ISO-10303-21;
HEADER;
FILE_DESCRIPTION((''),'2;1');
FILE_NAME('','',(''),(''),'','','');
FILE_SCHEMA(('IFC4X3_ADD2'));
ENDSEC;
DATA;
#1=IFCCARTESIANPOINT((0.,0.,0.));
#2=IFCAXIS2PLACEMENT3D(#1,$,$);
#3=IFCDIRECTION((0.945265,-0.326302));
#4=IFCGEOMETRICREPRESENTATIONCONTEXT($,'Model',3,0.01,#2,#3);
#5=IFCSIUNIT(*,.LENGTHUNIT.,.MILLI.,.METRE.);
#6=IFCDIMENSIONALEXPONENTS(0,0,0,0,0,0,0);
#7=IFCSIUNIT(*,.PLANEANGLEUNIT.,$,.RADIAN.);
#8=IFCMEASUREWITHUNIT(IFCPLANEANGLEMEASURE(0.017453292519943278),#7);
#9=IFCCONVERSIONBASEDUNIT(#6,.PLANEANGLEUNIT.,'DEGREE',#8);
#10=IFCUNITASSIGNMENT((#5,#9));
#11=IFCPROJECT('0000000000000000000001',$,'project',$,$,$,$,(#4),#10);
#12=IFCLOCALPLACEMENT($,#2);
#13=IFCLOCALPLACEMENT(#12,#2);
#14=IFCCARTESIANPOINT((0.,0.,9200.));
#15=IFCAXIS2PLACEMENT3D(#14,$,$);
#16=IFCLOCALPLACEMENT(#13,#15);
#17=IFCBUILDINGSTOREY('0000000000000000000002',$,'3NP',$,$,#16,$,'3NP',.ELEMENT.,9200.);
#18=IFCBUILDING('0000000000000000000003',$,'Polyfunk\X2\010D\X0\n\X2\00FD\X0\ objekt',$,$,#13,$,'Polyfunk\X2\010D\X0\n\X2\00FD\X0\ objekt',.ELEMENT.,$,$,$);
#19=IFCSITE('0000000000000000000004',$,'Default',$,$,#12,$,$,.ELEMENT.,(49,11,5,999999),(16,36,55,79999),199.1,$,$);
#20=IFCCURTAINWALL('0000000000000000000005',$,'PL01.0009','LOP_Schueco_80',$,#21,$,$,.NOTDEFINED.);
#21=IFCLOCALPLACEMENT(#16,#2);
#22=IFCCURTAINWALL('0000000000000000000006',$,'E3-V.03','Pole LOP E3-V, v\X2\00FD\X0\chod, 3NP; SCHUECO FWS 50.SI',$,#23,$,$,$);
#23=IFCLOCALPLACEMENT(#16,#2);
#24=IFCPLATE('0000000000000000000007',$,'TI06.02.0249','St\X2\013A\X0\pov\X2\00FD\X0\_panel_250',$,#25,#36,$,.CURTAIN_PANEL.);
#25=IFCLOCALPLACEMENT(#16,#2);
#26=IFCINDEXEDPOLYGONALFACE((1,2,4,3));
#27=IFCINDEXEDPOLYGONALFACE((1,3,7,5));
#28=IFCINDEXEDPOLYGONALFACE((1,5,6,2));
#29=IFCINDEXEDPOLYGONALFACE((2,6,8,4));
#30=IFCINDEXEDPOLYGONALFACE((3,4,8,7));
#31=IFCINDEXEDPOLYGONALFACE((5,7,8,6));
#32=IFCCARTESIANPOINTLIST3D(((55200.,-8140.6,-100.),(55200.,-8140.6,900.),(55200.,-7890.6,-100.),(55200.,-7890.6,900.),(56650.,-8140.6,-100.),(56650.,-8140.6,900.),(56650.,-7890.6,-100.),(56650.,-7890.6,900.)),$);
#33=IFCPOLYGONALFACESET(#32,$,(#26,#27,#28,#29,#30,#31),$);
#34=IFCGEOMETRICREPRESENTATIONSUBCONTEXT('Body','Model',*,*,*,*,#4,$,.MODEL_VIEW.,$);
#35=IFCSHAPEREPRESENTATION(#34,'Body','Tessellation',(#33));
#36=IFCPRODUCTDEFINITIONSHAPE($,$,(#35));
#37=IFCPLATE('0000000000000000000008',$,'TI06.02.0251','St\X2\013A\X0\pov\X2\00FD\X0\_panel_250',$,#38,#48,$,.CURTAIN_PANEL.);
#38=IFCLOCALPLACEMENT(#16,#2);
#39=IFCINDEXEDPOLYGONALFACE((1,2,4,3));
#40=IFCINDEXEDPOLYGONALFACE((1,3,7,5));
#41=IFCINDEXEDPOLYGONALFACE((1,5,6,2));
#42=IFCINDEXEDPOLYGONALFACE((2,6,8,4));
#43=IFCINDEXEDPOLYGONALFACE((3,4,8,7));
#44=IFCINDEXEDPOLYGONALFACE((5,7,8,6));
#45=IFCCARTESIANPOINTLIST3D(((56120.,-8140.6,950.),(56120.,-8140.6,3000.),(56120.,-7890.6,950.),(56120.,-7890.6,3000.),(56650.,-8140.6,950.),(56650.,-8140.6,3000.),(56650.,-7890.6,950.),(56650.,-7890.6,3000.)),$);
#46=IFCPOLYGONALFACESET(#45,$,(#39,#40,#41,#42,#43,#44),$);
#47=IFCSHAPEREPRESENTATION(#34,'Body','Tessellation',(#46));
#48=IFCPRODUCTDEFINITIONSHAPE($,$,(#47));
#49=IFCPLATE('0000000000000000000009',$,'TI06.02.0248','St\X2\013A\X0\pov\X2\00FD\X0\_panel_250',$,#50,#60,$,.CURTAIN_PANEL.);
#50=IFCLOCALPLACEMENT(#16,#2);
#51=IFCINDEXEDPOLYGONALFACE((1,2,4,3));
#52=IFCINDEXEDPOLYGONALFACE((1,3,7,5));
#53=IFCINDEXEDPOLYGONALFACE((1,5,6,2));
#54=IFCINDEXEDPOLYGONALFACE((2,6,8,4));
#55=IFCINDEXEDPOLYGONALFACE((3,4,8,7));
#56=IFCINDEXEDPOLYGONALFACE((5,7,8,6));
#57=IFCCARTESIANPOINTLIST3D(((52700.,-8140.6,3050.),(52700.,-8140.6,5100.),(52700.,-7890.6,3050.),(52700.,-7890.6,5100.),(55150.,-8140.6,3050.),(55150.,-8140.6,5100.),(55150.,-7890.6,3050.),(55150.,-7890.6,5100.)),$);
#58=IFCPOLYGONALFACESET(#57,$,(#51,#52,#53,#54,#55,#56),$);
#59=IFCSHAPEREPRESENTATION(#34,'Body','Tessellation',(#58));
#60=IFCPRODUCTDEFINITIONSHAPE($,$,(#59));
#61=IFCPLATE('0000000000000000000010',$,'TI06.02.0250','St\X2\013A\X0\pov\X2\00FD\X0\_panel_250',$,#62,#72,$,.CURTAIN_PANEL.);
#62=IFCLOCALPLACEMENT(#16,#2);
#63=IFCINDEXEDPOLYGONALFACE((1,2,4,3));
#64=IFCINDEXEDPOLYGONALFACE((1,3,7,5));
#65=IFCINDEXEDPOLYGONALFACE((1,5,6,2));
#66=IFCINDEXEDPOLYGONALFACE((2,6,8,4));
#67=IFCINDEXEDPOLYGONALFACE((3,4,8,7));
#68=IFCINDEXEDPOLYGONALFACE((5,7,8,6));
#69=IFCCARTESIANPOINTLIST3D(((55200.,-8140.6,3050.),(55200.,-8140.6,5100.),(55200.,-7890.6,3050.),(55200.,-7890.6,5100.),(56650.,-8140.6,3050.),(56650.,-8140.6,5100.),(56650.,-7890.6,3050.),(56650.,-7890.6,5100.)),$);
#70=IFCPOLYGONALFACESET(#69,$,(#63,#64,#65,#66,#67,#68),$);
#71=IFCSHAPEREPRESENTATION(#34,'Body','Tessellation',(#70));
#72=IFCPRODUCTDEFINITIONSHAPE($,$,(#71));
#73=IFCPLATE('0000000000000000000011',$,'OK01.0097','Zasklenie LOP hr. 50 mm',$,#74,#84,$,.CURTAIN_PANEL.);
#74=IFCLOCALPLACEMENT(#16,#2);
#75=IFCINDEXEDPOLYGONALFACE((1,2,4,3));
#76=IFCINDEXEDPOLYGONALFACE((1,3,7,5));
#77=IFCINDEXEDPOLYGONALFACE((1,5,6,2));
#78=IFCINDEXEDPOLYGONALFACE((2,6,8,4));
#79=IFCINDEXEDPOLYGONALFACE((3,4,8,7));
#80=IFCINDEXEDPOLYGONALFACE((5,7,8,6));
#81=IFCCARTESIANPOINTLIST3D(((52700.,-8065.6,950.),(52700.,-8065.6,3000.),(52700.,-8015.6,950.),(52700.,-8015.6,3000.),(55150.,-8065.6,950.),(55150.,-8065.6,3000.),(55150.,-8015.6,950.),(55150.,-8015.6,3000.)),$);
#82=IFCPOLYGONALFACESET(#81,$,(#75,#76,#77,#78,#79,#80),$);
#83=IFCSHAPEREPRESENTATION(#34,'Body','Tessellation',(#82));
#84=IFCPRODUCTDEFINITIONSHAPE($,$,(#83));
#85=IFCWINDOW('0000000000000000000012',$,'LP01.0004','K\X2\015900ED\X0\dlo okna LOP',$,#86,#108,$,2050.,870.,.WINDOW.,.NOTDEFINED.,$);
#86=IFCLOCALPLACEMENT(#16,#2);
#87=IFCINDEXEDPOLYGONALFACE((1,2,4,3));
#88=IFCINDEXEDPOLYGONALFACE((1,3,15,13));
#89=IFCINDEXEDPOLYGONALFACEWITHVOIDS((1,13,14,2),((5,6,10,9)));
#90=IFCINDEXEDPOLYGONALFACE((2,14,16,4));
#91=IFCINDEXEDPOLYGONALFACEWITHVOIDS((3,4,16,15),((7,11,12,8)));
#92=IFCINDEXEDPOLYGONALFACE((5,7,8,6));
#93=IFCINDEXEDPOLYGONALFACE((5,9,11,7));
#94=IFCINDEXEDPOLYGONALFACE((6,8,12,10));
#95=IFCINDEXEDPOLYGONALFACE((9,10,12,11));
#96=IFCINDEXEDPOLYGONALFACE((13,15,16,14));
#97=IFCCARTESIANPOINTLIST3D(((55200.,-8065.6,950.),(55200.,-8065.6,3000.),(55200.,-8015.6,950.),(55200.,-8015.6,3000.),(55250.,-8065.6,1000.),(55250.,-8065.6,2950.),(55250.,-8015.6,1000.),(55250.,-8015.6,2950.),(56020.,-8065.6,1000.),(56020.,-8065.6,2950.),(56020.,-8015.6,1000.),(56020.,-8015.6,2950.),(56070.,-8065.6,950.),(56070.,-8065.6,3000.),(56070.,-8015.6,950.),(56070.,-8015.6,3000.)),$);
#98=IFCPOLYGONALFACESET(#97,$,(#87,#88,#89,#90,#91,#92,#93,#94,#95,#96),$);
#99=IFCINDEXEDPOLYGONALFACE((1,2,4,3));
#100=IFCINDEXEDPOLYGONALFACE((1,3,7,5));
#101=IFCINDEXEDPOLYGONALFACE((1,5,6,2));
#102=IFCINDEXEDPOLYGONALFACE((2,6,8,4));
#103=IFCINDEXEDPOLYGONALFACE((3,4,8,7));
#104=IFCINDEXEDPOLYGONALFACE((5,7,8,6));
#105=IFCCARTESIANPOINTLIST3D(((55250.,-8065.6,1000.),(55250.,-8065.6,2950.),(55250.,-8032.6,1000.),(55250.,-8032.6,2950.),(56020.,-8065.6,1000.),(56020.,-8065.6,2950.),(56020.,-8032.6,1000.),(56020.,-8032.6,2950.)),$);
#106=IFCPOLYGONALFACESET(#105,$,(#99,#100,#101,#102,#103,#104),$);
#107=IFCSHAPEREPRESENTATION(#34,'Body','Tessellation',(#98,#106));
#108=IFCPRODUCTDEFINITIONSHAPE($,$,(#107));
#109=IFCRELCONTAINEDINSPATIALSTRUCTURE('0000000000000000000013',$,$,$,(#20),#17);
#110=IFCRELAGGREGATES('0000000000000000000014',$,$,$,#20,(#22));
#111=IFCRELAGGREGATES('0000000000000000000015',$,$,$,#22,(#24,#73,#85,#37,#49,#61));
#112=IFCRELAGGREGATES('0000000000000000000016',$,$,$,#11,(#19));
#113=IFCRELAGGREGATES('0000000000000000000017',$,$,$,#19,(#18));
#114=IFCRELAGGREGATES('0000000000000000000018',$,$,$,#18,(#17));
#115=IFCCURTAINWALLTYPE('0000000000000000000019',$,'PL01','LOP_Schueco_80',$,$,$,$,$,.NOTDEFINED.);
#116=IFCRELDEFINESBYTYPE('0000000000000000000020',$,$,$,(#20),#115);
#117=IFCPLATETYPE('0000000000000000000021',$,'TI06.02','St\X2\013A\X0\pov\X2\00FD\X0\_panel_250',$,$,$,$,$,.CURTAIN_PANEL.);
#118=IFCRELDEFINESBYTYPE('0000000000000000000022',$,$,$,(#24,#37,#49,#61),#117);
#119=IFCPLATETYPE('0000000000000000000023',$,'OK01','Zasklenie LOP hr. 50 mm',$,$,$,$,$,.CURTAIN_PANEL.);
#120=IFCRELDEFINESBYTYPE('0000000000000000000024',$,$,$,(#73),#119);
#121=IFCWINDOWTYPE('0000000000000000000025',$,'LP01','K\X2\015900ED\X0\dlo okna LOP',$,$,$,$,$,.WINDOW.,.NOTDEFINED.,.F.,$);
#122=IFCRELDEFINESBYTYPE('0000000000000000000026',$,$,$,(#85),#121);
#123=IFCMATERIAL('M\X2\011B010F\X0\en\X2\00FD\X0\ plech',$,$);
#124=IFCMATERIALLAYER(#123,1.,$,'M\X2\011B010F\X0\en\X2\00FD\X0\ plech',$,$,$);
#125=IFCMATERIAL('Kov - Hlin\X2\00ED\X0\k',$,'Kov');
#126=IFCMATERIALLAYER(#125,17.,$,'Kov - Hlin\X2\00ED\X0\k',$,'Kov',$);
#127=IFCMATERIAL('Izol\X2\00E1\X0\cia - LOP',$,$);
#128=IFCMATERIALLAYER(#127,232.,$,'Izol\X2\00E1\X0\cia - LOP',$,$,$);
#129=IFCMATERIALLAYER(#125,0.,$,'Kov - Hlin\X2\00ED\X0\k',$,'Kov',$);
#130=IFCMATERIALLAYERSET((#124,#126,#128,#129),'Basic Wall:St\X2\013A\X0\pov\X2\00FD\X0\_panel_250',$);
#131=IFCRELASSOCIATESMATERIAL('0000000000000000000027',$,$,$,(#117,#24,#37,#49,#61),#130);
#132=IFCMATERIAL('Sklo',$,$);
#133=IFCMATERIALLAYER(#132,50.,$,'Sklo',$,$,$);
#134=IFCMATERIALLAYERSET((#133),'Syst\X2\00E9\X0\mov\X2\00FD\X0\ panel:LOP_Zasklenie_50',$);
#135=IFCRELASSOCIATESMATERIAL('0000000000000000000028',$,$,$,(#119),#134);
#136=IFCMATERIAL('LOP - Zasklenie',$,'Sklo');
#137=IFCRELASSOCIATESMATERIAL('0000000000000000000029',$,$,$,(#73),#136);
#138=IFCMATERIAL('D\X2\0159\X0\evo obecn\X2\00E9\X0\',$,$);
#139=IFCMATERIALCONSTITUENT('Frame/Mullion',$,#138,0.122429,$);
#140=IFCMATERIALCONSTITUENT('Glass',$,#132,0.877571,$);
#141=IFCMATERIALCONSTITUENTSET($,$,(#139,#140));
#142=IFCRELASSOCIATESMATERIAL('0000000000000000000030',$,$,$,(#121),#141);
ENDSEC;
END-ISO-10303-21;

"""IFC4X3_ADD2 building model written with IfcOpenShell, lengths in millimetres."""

from ifc_helpers import new_model, entity, si_unit, converted_unit, direction, frame, frame_2d, origin, origin_2d_with_axis, place, context, subcontext, project, spatial, polyline, rectangle, outline, extrude, source, transform, mapped, material, layer, layer_set, layer_usage, constituent, constituent_set, type_object, type_shapes, element, aggregate, save


model = new_model("IFC4X3_ADD2")

# Units and contexts
model_context = context("Model", 3, precision=0.01, world=origin(), true_north=direction((0.945265, -0.326302)))
body_context = subcontext(model_context, "Body", "Model", "MODEL_VIEW")
ifc_project = project(units=[si_unit("LENGTHUNIT", "METRE", prefix="MILLI"), converted_unit("PLANEANGLEUNIT", "DEGREE", entity("IfcPlaneAngleMeasure", 0.017453292519943278), si_unit("PLANEANGLEUNIT", "RADIAN"), dimensions=[0, 0, 0, 0, 0, 0, 0])], contexts=[model_context])

# Site, building, storey
site_placement = place(None, origin())
site = spatial("IfcSite", under=ifc_project, at=site_placement, Name="Default", CompositionType="ELEMENT", RefLatitude=(49, 11, 5, 999999), RefLongitude=(16, 36, 55, 79999), RefElevation=199.1)
building_placement = place(site_placement, origin())
building = spatial("IfcBuilding", under=site, at=building_placement, Name="Polyfunkčný objekt", LongName="Polyfunkčný objekt", CompositionType="ELEMENT")
storey_placement = place(building_placement, frame((0.0, 0.0, 9200.0)))
storey = spatial("IfcBuildingStorey", under=building, at=storey_placement, Name="3NP", LongName="3NP", CompositionType="ELEMENT", Elevation=9200.0)

# Curtain walls, plates, window
curtain_wall_type = type_object("IfcCurtainWallType", Name="PL01", Description="LOP_Schueco_80", PredefinedType="NOTDEFINED")
curtain_wall_1_placement = place(storey_placement, frame((0.0, 0.0, -9200.0)))
curtain_wall_1 = element("IfcCurtainWall", 1, at=curtain_wall_1_placement, inside=storey, type_object=curtain_wall_type, Name="PL01.0009", Description="LOP_Schueco_80", PredefinedType="NOTDEFINED")
curtain_wall_2 = element("IfcCurtainWall", 2, Name="E3-V.03", Description="Pole LOP E3-V, východ, 3NP; SCHUECO FWS 50.SI")
aggregate(curtain_wall_1, [curtain_wall_2])
ifc_material_1 = material(Name="Měďený plech")
ifc_layer_1 = layer(ifc_material_1, 1.0, Name="Měďený plech")
ifc_material_2 = material(Name="Kov - Hliník", Category="Kov")
ifc_layer_2 = layer(ifc_material_2, 17.0, Name="Kov - Hliník", Category="Kov")
ifc_material_3 = material(Name="Izolácia - LOP")
ifc_layer_3 = layer(ifc_material_3, 232.0, Name="Izolácia - LOP")
ifc_layer_4 = layer(ifc_material_2, 0.0, Name="Kov - Hliník", Category="Kov")
ifc_layer_set_1 = layer_set([ifc_layer_1, ifc_layer_2, ifc_layer_3, ifc_layer_4], Name="Basic Wall:Stĺpový_panel_250")
ifc_layer_usage_1 = layer_usage(ifc_layer_set_1, "AXIS2", "POSITIVE", -125.0)
plate_type_1 = type_object("IfcPlateType", Name="TI06.02", Description="Stĺpový_panel_250", PredefinedType="CURTAIN_PANEL", material=ifc_layer_set_1)
plate_1_placement = place(storey_placement, frame((55200.0, -8015.6, -100.0)))
plate_1 = element("IfcPlate", 3, at=plate_1_placement, type_object=plate_type_1, material=ifc_layer_usage_1, Name="TI06.02.0249", Description="Stĺpový_panel_250", PredefinedType="CURTAIN_PANEL", context=body_context, shape_type="SweptSolid", body=[
    extrude(rectangle(XDim=250.0, YDim=1450.0, at=frame_2d((0.0, 0.0), x_axis=(1.0, 0.0))), frame((725.0, 0.0, 0.0), z_axis=(0.0, 0.0, 1.0), x_axis=(0.0, 1.0, 0.0)), (0.0, 0.0, 1.0), 1000.0),
])
ifc_layer_usage_2 = layer_usage(ifc_layer_set_1, "AXIS2", "POSITIVE", -125.0)
plate_2_placement = place(storey_placement, frame((56120.0, -8015.6, 950.0)))
plate_2 = element("IfcPlate", 4, at=plate_2_placement, type_object=plate_type_1, material=ifc_layer_usage_2, Name="TI06.02.0251", Description="Stĺpový_panel_250", PredefinedType="CURTAIN_PANEL", context=body_context, shape_type="SweptSolid", body=[
    extrude(rectangle(XDim=250.0, YDim=530.0, at=origin_2d_with_axis()), frame((265.0, 0.0, 0.0), z_axis=(0.0, 0.0, 1.0), x_axis=(0.0, 1.0, 0.0)), (0.0, 0.0, 1.0), 2050.0),
])
ifc_layer_usage_3 = layer_usage(ifc_layer_set_1, "AXIS2", "POSITIVE", -125.0)
plate_3_placement = place(storey_placement, frame((52700.0, -8015.6, 3050.0)))
plate_3 = element("IfcPlate", 5, at=plate_3_placement, type_object=plate_type_1, material=ifc_layer_usage_3, Name="TI06.02.0248", Description="Stĺpový_panel_250", PredefinedType="CURTAIN_PANEL", context=body_context, shape_type="SweptSolid", body=[
    extrude(rectangle(XDim=250.0, YDim=2450.0, at=frame_2d((0.0, 0.0), x_axis=(1.0, 0.0))), frame((1225.0, 0.0, 0.0), z_axis=(0.0, 0.0, 1.0), x_axis=(0.0, 1.0, 0.0)), (0.0, 0.0, 1.0), 2050.0),
])
ifc_layer_usage_4 = layer_usage(ifc_layer_set_1, "AXIS2", "POSITIVE", -125.0)
plate_4_placement = place(storey_placement, frame((55200.0, -8015.6, 3050.0)))
plate_4 = element("IfcPlate", 6, at=plate_4_placement, type_object=plate_type_1, material=ifc_layer_usage_4, Name="TI06.02.0250", Description="Stĺpový_panel_250", PredefinedType="CURTAIN_PANEL", context=body_context, shape_type="SweptSolid", body=[
    extrude(rectangle(XDim=250.0, YDim=1450.0, at=frame_2d((0.0, 0.0), x_axis=(1.0, 0.0))), frame((725.0, 0.0, 0.0), z_axis=(0.0, 0.0, 1.0), x_axis=(0.0, 1.0, 0.0)), (0.0, 0.0, 1.0), 2050.0),
])
ifc_material_4 = material(Name="LOP - Zasklenie", Category="Sklo")
ifc_material_5 = material(Name="Sklo")
ifc_layer_5 = layer(ifc_material_5, 50.0, Name="Sklo")
ifc_layer_set_2 = layer_set([ifc_layer_5], Name="Systémový panel:LOP_Zasklenie_50")
plate_type_2 = type_object("IfcPlateType", Name="OK01", Description="Zasklenie LOP hr. 50 mm", PredefinedType="CURTAIN_PANEL", material=ifc_layer_set_2)
shared_shape_1 = source(origin(), body_context, "Body", "SweptSolid", [
    extrude(rectangle(XDim=50.0, YDim=2450.0, at=origin_2d_with_axis()), frame((0.0, -25.0, 0.0), z_axis=(0.0, 0.0, 1.0), x_axis=(0.0, 1.0, 0.0)), (0.0, 0.0, 1.0), 2050.0),
])
type_shapes(plate_type_2, [shared_shape_1])
plate_5_placement = place(curtain_wall_1_placement, frame((53925.0, -8015.6, 10150.0)))
plate_5 = element("IfcPlate", 7, at=plate_5_placement, type_object=plate_type_2, material=ifc_material_4, Name="OK01.0097", Description="Zasklenie LOP hr. 50 mm", PredefinedType="CURTAIN_PANEL", context=body_context, shape_type="MappedRepresentation", body=[
    mapped(shared_shape_1, transform((0.0, 0.0, 0.0), scale=1.0)),
])
ifc_material_6 = material(Name="Dřevo obecné")
ifc_constituent_1 = constituent(ifc_material_6, Name="Frame/Mullion", fraction=0.122429)
ifc_constituent_2 = constituent(ifc_material_5, Name="Glass", fraction=0.877571)
ifc_constituent_set = constituent_set(constituents=[ifc_constituent_1, ifc_constituent_2])
window_type = type_object("IfcWindowType", Name="LP01", Description="Křídlo okna LOP", ParameterTakesPrecedence=False, PartitioningType="NOTDEFINED", PredefinedType="WINDOW", material=ifc_constituent_set)
shared_shape_2 = source(origin(), body_context, "Body", "SweptSolid", [
    extrude(outline(polyline([(-1025.0, -435.0), (1025.0, -435.0), (1025.0, 435.0), (-1025.0, 435.0), (-1025.0, -435.0)]), holes=[polyline([(-975.0, -385.0), (-975.0, 385.0), (975.0, 385.0), (975.0, -385.0), (-975.0, -385.0)])]), frame((0.0, 50.0, 1025.0), z_axis=(0.0, -1.0, 0.0), x_axis=(0.0, 0.0, -1.0)), (0.0, 0.0, 1.0), 50.0),
    extrude(rectangle(XDim=770.0, YDim=33.0, at=frame_2d((0.0, 0.0), x_axis=(1.0, 0.0))), frame((0.0, 33.5, 50.0), z_axis=(0.0, 0.0, 1.0), x_axis=(-1.0, 0.0, 0.0)), (0.0, 0.0, 1.0), 1950.0),
])
type_shapes(window_type, [shared_shape_2])
window_placement = place(curtain_wall_1_placement, frame((55635.0, -8015.6, 10150.0), z_axis=(0.0, 0.0, 1.0), x_axis=(-1.0, 0.0, 0.0)))
window = element("IfcWindow", 8, at=window_placement, type_object=window_type, Name="LP01.0004", Description="Křídlo okna LOP", OverallHeight=2050.0, OverallWidth=870.0, PartitioningType="NOTDEFINED", PredefinedType="WINDOW", context=body_context, shape_type="MappedRepresentation", body=[
    mapped(shared_shape_2, transform((0.0, 0.0, 0.0), scale=1.0)),
])
aggregate(curtain_wall_2, [plate_1, plate_5, window, plate_2, plate_3, plate_4])

save(model, "model.ifc")
